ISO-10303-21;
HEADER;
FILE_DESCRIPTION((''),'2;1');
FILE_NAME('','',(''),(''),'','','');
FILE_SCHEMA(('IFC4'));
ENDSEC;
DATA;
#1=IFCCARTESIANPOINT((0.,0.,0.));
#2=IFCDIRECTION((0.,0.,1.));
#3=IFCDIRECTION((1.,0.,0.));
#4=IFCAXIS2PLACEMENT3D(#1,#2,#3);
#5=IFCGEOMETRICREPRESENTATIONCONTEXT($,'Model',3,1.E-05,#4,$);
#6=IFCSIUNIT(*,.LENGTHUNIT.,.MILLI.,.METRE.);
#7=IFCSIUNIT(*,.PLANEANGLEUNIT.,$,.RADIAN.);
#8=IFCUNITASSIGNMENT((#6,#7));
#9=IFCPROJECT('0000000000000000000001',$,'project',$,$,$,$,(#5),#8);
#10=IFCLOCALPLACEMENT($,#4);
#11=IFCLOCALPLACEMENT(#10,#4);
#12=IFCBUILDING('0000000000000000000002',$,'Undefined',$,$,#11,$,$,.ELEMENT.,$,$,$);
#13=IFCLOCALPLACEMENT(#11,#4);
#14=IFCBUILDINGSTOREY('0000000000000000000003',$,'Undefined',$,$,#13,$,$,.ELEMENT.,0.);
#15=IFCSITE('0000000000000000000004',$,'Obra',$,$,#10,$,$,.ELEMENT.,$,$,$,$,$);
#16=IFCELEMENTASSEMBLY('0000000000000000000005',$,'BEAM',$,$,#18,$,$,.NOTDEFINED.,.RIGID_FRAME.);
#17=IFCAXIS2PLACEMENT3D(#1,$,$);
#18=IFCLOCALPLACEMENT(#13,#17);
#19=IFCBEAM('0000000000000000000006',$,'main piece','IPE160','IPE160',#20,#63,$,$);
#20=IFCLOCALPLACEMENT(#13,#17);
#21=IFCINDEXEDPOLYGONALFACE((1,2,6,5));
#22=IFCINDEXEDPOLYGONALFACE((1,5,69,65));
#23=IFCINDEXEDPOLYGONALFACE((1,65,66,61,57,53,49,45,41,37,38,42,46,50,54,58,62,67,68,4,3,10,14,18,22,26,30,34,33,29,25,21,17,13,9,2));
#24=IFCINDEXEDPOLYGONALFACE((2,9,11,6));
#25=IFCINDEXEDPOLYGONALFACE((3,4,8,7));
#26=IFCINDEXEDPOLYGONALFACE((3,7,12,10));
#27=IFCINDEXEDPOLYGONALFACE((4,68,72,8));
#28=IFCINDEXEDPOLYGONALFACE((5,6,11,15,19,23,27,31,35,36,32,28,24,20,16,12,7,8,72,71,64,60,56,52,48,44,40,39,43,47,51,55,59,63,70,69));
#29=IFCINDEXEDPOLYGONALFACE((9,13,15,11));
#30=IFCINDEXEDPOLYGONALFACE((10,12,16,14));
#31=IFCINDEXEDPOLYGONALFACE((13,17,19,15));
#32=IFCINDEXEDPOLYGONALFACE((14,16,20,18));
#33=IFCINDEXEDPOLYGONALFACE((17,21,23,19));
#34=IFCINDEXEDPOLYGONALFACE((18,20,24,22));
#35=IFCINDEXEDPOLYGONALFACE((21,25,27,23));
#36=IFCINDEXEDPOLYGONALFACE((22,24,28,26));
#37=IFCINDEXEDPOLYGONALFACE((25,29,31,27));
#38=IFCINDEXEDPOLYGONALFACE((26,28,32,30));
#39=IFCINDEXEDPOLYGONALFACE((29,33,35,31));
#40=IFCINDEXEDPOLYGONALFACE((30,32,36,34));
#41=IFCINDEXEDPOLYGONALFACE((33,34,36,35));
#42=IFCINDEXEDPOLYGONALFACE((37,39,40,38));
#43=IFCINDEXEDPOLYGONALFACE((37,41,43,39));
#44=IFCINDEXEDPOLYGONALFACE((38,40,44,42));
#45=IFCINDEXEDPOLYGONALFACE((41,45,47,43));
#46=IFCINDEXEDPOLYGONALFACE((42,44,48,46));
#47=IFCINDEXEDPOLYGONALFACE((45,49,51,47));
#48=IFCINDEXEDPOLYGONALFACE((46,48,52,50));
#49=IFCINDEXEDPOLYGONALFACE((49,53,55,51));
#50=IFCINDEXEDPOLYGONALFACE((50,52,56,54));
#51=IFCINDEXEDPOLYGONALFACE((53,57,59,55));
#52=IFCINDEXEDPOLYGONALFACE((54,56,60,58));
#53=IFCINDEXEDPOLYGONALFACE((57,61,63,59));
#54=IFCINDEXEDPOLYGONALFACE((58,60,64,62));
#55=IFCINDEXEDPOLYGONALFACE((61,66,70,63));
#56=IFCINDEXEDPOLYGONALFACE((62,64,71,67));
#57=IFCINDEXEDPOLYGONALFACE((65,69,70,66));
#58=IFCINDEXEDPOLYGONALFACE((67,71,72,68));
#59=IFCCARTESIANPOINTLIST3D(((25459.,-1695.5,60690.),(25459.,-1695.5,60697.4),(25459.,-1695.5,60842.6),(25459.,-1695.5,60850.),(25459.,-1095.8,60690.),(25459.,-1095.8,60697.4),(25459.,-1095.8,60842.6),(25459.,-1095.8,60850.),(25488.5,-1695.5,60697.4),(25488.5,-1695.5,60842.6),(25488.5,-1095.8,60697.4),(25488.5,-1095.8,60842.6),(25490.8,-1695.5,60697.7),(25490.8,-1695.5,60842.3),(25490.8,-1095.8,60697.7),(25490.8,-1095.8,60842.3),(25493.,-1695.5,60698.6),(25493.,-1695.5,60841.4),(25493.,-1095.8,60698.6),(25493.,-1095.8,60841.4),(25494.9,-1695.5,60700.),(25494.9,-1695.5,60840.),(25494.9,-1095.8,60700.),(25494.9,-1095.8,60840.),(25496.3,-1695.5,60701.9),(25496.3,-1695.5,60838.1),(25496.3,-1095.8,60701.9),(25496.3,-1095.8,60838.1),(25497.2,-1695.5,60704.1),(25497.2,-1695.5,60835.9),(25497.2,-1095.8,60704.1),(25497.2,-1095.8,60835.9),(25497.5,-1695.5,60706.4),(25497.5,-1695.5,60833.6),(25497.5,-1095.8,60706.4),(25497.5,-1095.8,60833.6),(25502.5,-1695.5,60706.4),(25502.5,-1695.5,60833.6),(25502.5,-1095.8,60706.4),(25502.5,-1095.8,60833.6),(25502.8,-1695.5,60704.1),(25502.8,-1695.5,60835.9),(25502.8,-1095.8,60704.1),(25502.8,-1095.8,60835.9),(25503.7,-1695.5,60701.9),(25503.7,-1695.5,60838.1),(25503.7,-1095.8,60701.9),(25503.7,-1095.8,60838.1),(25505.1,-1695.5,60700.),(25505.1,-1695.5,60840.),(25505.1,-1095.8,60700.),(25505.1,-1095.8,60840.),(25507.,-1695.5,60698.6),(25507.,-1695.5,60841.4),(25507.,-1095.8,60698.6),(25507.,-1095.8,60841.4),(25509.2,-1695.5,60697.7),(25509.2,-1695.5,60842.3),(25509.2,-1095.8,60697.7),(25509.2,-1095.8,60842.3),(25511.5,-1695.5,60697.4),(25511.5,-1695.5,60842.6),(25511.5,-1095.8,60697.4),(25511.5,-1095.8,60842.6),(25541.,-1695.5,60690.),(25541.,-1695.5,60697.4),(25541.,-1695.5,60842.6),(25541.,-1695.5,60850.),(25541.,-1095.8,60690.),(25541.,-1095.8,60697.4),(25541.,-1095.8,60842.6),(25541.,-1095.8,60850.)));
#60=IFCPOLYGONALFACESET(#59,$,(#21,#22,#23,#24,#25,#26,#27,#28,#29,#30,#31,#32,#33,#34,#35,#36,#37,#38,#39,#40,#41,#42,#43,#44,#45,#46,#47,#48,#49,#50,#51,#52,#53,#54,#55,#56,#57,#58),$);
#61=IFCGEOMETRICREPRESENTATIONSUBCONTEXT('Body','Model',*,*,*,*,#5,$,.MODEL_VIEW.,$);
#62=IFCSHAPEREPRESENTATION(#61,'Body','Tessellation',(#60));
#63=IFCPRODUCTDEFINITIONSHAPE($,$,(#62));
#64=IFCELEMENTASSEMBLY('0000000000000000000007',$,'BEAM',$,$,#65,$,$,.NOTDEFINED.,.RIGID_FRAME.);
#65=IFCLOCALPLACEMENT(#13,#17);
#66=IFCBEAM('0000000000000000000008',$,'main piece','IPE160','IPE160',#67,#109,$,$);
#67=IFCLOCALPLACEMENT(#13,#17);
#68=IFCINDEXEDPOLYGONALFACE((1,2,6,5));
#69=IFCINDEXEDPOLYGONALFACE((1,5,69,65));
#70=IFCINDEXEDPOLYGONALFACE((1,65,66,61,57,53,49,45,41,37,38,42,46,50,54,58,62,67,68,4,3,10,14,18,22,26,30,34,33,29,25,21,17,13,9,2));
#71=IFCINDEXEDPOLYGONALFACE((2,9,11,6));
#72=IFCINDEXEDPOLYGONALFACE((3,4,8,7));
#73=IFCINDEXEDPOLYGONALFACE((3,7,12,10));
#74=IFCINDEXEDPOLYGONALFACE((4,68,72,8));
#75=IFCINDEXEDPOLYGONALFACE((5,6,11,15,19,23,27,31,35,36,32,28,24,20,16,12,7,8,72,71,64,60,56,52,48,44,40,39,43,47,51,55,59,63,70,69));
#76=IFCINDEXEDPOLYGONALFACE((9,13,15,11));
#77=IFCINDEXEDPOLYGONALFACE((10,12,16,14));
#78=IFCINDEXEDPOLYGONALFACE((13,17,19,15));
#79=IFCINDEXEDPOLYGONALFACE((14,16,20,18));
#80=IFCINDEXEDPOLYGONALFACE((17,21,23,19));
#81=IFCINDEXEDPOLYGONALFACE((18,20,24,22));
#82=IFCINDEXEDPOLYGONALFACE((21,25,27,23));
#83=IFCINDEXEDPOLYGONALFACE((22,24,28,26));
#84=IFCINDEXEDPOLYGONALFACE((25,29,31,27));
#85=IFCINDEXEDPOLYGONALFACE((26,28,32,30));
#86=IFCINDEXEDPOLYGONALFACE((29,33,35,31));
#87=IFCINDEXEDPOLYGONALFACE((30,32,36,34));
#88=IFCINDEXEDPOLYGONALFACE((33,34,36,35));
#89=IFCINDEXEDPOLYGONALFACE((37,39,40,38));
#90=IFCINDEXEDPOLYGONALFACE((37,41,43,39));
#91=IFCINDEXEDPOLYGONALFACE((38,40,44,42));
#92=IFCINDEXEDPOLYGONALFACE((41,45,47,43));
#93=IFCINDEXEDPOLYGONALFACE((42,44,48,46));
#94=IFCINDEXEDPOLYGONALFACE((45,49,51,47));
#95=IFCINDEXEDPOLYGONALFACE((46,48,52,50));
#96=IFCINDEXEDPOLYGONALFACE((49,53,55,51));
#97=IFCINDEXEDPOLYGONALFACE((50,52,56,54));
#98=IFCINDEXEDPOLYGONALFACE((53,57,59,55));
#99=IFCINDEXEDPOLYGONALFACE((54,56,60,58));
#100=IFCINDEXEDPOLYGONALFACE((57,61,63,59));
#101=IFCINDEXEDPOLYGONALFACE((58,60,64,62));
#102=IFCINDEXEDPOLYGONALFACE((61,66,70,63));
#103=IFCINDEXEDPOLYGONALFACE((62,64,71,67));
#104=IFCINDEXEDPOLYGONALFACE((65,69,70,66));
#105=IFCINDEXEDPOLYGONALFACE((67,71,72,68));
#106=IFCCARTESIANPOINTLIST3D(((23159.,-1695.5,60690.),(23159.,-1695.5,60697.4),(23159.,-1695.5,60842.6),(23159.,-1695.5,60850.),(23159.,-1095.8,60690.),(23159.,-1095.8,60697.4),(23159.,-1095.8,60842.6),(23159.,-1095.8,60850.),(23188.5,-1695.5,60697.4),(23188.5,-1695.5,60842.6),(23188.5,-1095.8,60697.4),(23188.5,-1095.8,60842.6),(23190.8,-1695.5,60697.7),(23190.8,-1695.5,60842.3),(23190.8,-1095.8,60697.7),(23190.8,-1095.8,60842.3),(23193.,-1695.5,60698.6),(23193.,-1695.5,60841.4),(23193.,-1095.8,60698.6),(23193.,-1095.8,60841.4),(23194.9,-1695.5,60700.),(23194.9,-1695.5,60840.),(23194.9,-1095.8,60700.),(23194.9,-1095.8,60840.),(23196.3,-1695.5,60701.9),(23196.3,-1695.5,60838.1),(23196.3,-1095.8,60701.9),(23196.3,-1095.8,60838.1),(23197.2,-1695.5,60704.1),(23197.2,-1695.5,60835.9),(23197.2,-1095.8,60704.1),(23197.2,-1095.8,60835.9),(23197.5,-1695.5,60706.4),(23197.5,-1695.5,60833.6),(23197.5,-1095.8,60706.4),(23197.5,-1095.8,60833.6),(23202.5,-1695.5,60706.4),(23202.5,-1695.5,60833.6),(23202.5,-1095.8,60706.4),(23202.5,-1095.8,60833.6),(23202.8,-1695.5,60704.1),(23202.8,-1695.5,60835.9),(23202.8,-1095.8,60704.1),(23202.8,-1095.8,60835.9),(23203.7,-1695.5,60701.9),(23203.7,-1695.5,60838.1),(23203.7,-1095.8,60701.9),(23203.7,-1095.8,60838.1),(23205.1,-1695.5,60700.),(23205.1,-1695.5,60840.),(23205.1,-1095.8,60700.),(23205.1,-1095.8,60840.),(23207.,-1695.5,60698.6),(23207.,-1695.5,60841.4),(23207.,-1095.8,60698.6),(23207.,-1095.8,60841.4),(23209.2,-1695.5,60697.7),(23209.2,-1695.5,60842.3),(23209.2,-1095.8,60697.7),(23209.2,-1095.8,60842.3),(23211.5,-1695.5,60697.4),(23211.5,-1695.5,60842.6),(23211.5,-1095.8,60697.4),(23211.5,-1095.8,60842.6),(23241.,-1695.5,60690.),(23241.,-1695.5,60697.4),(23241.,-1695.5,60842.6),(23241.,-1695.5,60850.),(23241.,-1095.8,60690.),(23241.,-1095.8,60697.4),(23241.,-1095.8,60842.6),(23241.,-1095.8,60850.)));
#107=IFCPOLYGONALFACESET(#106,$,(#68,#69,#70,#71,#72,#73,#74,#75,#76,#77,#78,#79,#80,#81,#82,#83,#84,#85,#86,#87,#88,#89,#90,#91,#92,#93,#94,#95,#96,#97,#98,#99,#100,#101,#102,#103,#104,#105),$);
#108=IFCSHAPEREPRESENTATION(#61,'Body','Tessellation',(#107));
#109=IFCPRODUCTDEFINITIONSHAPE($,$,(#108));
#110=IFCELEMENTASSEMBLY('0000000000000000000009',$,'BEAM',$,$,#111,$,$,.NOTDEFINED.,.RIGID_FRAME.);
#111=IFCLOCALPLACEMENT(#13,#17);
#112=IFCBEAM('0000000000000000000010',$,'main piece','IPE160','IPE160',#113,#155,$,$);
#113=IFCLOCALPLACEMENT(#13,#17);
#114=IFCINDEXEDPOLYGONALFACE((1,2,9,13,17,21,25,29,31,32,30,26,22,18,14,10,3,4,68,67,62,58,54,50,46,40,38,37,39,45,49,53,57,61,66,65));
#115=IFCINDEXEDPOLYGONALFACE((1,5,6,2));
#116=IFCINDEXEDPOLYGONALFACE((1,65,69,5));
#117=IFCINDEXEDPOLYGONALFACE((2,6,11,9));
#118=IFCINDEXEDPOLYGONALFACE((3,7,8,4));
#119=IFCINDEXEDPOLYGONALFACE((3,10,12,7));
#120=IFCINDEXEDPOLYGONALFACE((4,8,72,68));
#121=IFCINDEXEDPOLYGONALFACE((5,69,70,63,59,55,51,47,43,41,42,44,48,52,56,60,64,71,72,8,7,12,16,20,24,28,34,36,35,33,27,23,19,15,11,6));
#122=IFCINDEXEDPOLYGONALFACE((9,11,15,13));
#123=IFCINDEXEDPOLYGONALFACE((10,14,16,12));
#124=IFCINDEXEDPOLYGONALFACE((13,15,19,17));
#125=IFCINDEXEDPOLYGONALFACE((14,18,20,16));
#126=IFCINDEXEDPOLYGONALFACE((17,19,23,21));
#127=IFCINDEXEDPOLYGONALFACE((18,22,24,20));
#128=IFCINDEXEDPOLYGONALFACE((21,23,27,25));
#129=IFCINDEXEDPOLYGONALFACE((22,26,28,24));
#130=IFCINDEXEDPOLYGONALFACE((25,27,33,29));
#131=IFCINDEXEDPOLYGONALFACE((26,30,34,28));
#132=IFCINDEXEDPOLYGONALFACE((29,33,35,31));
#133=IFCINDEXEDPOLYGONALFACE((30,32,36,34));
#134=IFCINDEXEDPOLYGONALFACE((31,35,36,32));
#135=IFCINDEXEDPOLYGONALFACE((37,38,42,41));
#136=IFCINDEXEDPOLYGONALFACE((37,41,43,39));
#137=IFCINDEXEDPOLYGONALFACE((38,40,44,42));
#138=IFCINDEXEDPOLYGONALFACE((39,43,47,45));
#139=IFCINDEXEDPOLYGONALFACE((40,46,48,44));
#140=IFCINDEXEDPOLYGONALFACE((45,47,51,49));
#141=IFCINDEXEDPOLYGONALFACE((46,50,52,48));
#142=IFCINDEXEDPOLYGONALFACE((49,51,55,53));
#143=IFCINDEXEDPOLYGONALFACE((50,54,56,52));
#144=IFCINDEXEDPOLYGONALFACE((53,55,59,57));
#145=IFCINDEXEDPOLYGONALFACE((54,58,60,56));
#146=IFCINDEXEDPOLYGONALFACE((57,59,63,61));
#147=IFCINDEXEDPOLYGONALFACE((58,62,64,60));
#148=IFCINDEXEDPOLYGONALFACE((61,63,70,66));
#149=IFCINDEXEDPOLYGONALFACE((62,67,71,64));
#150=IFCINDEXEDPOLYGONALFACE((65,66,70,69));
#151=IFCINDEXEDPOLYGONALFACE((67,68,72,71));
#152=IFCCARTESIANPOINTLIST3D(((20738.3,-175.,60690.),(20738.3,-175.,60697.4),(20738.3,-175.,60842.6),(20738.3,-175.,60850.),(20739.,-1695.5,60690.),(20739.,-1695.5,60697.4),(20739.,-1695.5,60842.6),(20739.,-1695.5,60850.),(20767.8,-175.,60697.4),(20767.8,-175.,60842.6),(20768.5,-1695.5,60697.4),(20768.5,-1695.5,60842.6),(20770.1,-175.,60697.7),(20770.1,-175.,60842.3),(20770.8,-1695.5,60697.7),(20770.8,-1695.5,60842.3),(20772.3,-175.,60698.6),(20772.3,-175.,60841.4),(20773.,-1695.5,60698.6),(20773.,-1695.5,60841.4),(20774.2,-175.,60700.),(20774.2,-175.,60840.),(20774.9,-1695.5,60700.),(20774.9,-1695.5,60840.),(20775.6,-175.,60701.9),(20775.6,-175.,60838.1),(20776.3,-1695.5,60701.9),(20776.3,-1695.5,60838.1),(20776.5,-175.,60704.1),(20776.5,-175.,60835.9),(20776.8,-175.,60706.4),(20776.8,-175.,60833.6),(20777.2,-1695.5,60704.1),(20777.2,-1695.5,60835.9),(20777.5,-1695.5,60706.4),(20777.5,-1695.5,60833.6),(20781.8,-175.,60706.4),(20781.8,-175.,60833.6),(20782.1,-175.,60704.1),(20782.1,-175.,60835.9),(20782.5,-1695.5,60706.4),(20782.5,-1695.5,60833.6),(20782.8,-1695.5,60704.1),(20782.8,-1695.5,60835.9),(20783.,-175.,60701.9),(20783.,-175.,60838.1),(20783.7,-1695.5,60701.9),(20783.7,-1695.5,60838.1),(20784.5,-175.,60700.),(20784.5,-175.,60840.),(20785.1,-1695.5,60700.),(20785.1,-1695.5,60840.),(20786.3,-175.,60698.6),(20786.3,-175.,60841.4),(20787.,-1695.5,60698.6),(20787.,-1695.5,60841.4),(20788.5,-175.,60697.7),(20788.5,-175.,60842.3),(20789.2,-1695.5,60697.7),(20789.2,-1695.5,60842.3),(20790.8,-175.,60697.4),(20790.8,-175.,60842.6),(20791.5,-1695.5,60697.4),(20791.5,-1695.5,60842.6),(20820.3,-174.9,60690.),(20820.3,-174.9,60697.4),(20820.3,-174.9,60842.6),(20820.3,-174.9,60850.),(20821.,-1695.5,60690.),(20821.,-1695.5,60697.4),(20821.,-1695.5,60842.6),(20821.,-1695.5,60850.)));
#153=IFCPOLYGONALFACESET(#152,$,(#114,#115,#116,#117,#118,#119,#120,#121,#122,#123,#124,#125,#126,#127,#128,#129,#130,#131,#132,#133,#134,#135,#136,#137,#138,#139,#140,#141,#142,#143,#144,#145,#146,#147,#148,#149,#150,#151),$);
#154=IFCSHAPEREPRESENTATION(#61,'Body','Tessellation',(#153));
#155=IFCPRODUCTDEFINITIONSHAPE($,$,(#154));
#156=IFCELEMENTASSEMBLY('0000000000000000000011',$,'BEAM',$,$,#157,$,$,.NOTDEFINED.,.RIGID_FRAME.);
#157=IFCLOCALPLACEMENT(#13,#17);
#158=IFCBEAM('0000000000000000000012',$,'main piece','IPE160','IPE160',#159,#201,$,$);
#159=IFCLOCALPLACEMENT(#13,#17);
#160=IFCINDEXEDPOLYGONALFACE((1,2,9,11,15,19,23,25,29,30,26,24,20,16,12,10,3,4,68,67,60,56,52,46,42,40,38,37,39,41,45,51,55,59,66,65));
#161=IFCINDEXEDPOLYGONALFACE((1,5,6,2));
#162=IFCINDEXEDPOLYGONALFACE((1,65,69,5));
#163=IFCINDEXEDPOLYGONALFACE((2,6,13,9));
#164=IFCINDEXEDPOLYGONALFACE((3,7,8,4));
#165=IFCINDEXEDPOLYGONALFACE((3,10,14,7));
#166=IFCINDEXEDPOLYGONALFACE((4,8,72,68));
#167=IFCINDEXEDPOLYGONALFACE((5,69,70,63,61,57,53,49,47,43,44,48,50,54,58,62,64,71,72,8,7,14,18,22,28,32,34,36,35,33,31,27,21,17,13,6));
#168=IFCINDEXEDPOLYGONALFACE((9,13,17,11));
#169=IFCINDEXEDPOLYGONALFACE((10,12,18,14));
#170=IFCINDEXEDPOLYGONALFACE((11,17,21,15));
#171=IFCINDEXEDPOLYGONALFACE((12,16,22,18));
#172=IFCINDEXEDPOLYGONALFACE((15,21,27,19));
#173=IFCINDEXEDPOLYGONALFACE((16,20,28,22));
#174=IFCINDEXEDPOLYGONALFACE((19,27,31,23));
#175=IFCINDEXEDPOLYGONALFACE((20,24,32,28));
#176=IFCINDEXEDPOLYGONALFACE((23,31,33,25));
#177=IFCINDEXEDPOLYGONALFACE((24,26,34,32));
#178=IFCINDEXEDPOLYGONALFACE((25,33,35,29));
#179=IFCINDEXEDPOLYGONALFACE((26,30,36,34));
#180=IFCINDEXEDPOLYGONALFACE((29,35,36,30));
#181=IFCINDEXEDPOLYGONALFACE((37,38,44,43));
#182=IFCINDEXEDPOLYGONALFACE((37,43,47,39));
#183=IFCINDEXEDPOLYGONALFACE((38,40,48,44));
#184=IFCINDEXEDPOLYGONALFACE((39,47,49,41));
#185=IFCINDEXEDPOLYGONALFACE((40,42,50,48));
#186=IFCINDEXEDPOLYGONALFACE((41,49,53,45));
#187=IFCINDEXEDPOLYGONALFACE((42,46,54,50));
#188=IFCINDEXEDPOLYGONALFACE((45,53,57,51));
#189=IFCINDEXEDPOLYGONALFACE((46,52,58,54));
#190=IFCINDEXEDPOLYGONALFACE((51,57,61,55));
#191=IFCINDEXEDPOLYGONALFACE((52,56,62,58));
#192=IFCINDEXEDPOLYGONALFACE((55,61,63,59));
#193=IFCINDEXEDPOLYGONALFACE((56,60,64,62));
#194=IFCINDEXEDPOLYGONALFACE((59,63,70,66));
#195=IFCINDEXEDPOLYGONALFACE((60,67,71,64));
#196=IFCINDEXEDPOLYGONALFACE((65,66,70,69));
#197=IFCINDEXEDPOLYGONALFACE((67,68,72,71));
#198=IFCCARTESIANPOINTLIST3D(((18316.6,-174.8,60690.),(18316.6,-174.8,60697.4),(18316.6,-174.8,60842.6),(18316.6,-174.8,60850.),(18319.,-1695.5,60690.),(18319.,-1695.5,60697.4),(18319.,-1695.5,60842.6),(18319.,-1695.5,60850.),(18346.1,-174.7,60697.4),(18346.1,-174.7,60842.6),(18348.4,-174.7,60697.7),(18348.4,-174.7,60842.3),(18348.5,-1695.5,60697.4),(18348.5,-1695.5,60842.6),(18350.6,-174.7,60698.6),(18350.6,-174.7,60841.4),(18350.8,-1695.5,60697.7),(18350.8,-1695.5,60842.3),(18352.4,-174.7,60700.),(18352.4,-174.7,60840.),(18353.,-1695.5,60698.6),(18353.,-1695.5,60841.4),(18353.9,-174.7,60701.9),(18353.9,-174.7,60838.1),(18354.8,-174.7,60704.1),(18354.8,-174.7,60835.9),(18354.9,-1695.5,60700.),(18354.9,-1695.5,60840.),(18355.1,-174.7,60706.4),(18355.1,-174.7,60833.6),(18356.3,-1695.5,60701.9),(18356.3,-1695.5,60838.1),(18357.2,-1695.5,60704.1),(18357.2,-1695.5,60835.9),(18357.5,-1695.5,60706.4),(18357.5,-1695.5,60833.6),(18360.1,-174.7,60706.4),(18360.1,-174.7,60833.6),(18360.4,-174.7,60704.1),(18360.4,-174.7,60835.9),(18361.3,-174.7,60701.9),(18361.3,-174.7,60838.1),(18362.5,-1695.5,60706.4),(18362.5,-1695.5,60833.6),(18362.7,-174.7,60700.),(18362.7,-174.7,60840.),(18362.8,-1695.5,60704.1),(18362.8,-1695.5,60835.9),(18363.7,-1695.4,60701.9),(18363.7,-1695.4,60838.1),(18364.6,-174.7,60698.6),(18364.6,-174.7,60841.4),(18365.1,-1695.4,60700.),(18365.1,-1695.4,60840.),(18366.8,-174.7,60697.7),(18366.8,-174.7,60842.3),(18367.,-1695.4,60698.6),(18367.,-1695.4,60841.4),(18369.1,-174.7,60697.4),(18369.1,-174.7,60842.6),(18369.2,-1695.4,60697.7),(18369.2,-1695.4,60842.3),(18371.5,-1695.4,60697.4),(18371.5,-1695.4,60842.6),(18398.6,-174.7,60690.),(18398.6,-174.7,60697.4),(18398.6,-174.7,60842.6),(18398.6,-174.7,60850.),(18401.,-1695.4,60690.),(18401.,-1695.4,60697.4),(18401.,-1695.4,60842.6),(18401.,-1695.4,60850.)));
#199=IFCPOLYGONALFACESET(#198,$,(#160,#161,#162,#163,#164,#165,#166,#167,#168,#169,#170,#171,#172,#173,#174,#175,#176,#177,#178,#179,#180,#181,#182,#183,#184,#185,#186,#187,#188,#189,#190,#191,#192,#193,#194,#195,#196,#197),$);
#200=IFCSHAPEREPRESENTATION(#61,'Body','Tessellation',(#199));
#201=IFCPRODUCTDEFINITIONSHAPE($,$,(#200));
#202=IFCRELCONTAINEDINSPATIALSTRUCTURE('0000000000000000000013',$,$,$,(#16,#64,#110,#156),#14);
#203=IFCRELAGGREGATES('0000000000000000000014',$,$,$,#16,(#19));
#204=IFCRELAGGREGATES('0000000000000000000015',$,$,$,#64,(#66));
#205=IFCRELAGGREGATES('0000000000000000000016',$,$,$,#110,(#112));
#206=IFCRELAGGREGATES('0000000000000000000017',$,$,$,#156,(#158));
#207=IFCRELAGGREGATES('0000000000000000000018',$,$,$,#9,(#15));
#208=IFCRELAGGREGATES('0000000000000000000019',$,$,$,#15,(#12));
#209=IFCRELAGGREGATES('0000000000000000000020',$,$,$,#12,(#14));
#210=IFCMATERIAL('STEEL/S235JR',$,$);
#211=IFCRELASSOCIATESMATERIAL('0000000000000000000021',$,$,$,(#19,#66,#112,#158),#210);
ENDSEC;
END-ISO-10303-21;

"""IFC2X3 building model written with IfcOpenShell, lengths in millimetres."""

from ifc_helpers import new_model, si_unit, frame, origin_with_axes, origin_2d_with_axis, place, context, subcontext, project, spatial, i_section, extrude, material, element, aggregate, save


model = new_model("IFC2X3")

# Units and contexts
model_context = context("Model", 3, precision=1e-05, world=origin_with_axes())
body_context = subcontext(model_context, "Body", "Model", "MODEL_VIEW")
ifc_project = project(units=[si_unit("LENGTHUNIT", "METRE", prefix="MILLI"), si_unit("PLANEANGLEUNIT", "RADIAN")], contexts=[model_context])

# Site, building, storey
site_placement = place(None, origin_with_axes())
site = spatial("IfcSite", under=ifc_project, at=site_placement, Name="Obra", CompositionType="ELEMENT")
building_placement = place(site_placement, origin_with_axes())
building = spatial("IfcBuilding", under=site, at=building_placement, Name="Undefined", CompositionType="ELEMENT")
storey_placement = place(building_placement, origin_with_axes())
storey = spatial("IfcBuildingStorey", under=building, at=storey_placement, Name="Undefined", CompositionType="ELEMENT", Elevation=0.0)

# Element assemblies, beams
ifc_material_1 = material(Name="STEEL/S235JR")
assembly_1_placement = place(storey_placement, origin_with_axes())
assembly_1 = element("IfcElementAssembly", 1, at=assembly_1_placement, inside=storey, Name="BEAM", AssemblyPlace="NOTDEFINED", PredefinedType="RIGID_FRAME")
beam_1_placement = place(assembly_1_placement, frame((25500.0, -1095.8, 60770.0), z_axis=(0.0, 0.0, 1.0), x_axis=(0.0, -1.0, 0.0)))
beam_1 = element("IfcBeam", 2, at=beam_1_placement, material=ifc_material_1, Name="main piece", Description="IPE160", ObjectType="IPE160", context=body_context, shape_type="SweptSolid", body=[
    extrude(i_section(OverallWidth=82.0, OverallDepth=160.0, WebThickness=5.0, FlangeThickness=7.4, FilletRadius=9.0, at=origin_2d_with_axis()), frame((599.7, 0.0, 0.0), z_axis=(-1.0, 0.0, 0.0), x_axis=(0.0, -1.0, 0.0)), (0.0, 0.0, 1.0), 599.7),
])
aggregate(assembly_1, [beam_1])
assembly_2_placement = place(storey_placement, origin_with_axes())
assembly_2 = element("IfcElementAssembly", 3, at=assembly_2_placement, inside=storey, Name="BEAM", AssemblyPlace="NOTDEFINED", PredefinedType="RIGID_FRAME")
beam_2_placement = place(assembly_2_placement, frame((23200.0, -1695.5, 60770.0), z_axis=(0.0, 0.0, 1.0), x_axis=(0.0, 1.0, 0.0)))
beam_2 = element("IfcBeam", 4, at=beam_2_placement, material=ifc_material_1, Name="main piece", Description="IPE160", ObjectType="IPE160", context=body_context, shape_type="SweptSolid", body=[
    extrude(i_section(OverallWidth=82.0, OverallDepth=160.0, WebThickness=5.0, FlangeThickness=7.4, FilletRadius=9.0, at=origin_2d_with_axis()), frame((599.7, 0.0, 0.0), z_axis=(-1.0, 0.0, 0.0), x_axis=(0.0, -1.0, 0.0)), (0.0, 0.0, 1.0), 599.7),
])
aggregate(assembly_2, [beam_2])
assembly_3_placement = place(storey_placement, origin_with_axes())
assembly_3 = element("IfcElementAssembly", 5, at=assembly_3_placement, inside=storey, Name="BEAM", AssemblyPlace="NOTDEFINED", PredefinedType="RIGID_FRAME")
beam_3_placement = place(assembly_3_placement, frame((20779.3, -175.0, 60770.0), z_axis=(0.0, 0.0, 1.0), x_axis=(0.00045, -1.0, 0.0)))
beam_3 = element("IfcBeam", 6, at=beam_3_placement, material=ifc_material_1, Name="main piece", Description="IPE160", ObjectType="IPE160", context=body_context, shape_type="SweptSolid", body=[
    extrude(i_section(OverallWidth=82.0, OverallDepth=160.0, WebThickness=5.0, FlangeThickness=7.4, FilletRadius=9.0, at=origin_2d_with_axis()), frame((1520.5, 0.0, 0.0), z_axis=(-1.0, 0.0, 0.0), x_axis=(0.0, -1.0, 0.0)), (0.0, 0.0, 1.0), 1520.5),
])
aggregate(assembly_3, [beam_3])
assembly_4_placement = place(storey_placement, origin_with_axes())
assembly_4 = element("IfcElementAssembly", 7, at=assembly_4_placement, inside=storey, Name="BEAM", AssemblyPlace="NOTDEFINED", PredefinedType="RIGID_FRAME")
beam_4_placement = place(assembly_4_placement, frame((18360.0, -1695.5, 60770.0), z_axis=(0.0, 0.0, 1.0), x_axis=(-0.001588, 0.999999, 0.0)))
beam_4 = element("IfcBeam", 8, at=beam_4_placement, material=ifc_material_1, Name="main piece", Description="IPE160", ObjectType="IPE160", context=body_context, shape_type="SweptSolid", body=[
    extrude(i_section(OverallWidth=82.0, OverallDepth=160.0, WebThickness=5.0, FlangeThickness=7.4, FilletRadius=9.0, at=origin_2d_with_axis()), frame((1520.7, 0.0, 0.0), z_axis=(-1.0, 0.0, 0.0), x_axis=(0.0, -1.0, 0.0)), (0.0, 0.0, 1.0), 1520.7),
])
aggregate(assembly_4, [beam_4])

save(model, "model.ifc")
